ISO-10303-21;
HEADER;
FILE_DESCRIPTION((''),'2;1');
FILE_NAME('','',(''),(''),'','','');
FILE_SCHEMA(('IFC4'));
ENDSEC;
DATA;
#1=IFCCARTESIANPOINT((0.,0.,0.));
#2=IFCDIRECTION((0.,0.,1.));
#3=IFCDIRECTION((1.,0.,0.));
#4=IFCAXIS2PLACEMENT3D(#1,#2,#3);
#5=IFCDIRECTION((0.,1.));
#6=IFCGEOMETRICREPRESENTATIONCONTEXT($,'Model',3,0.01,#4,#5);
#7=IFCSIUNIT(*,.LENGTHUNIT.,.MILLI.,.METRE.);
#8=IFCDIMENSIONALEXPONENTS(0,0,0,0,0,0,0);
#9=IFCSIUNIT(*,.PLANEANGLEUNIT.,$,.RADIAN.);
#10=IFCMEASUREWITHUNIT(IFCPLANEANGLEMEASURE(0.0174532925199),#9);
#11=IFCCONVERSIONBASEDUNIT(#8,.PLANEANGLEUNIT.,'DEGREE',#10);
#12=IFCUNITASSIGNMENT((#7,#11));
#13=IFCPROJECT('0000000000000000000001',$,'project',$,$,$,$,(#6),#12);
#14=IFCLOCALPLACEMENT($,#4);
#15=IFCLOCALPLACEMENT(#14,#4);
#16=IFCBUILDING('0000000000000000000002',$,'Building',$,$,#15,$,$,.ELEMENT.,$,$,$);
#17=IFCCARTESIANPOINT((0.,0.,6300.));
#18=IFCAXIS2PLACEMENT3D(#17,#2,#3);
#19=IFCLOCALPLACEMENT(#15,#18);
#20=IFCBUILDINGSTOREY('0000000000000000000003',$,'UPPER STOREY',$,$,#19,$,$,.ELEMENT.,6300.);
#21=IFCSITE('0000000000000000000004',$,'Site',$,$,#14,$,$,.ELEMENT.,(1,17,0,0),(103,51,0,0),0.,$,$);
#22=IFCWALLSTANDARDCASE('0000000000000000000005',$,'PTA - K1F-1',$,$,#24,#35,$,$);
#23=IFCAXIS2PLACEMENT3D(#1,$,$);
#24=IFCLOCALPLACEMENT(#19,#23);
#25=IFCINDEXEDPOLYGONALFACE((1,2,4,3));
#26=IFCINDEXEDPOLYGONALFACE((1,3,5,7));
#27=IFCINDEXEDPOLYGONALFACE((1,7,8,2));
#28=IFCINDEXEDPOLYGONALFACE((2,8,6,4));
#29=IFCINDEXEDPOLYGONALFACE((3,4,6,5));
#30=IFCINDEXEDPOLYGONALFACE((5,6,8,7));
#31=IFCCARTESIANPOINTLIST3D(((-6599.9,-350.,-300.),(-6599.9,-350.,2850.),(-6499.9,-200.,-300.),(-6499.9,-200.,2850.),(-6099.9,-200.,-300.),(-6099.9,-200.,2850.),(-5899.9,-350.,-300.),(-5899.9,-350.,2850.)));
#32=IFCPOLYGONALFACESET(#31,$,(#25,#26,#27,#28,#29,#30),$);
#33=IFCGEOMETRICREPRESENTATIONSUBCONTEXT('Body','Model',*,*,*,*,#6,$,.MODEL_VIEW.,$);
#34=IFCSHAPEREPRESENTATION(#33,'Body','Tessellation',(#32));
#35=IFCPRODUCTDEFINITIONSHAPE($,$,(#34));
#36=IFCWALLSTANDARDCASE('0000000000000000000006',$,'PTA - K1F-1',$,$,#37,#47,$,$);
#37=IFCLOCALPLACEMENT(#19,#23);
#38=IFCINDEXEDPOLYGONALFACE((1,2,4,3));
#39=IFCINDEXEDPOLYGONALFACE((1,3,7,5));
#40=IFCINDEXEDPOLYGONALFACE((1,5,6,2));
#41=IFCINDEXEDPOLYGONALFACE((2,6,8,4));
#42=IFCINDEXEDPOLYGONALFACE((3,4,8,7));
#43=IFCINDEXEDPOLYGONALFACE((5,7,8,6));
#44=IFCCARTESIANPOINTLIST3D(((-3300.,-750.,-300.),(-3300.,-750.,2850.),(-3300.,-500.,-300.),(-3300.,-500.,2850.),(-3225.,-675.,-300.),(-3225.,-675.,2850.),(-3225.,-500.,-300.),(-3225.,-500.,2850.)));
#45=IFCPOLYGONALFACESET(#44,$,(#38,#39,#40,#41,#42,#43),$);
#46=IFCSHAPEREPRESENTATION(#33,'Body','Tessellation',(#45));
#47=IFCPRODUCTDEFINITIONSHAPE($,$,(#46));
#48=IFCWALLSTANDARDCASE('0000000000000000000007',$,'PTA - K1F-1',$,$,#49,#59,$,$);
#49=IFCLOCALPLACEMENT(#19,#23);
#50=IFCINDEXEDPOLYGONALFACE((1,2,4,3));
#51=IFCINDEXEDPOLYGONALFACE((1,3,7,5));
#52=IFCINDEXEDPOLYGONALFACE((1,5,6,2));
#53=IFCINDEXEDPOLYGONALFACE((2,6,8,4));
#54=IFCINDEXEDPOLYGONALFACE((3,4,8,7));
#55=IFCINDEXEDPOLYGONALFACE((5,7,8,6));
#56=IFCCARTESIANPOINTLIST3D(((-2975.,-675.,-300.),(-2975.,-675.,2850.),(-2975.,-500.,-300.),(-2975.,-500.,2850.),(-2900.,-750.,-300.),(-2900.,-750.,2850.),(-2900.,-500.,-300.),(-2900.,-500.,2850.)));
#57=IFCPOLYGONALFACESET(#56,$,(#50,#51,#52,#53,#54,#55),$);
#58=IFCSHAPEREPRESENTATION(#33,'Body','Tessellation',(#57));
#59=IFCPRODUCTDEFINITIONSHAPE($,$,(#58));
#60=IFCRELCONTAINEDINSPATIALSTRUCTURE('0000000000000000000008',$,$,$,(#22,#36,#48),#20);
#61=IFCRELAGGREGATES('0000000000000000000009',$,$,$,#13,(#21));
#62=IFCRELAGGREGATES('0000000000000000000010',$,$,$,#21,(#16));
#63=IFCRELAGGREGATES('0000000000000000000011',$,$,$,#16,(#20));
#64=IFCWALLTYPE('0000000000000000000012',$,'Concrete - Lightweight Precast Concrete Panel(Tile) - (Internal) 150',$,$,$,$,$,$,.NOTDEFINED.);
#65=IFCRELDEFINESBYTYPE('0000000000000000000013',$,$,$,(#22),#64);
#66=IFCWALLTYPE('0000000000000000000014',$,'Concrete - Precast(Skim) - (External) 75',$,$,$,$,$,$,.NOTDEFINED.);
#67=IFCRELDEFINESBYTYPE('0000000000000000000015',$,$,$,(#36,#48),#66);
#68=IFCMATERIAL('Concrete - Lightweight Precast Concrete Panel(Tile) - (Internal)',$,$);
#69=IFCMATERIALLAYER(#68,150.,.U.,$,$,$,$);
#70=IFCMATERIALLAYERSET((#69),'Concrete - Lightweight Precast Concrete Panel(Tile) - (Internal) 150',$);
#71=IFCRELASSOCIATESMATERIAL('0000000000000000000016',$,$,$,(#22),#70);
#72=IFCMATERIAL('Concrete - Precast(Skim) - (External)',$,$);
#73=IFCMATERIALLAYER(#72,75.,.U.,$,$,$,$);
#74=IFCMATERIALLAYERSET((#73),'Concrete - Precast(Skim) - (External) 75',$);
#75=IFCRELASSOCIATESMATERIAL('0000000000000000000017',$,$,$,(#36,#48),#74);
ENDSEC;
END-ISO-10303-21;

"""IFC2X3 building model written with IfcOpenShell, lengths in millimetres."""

from ifc_helpers import new_model, entity, si_unit, converted_unit, direction, frame, origin_with_axes, place, context, subcontext, project, spatial, polyline, outline, extrude, material, layer, layer_set, layer_usage, type_object, element, save


model = new_model("IFC2X3")

# Units and contexts
model_context = context("Model", 3, precision=0.01, world=origin_with_axes(), true_north=direction((0.0, 1.0)))
body_context = subcontext(model_context, "Body", "Model", "MODEL_VIEW")
ifc_project = project(units=[si_unit("LENGTHUNIT", "METRE", prefix="MILLI"), converted_unit("PLANEANGLEUNIT", "DEGREE", entity("IfcPlaneAngleMeasure", 0.0174532925199), si_unit("PLANEANGLEUNIT", "RADIAN"), dimensions=[0, 0, 0, 0, 0, 0, 0])], contexts=[model_context])

# Site, building, storey
site_placement = place(None, origin_with_axes())
site = spatial("IfcSite", under=ifc_project, at=site_placement, Name="Site", CompositionType="ELEMENT", RefLatitude=(1, 17, 0, 0), RefLongitude=(103, 51, 0, 0), RefElevation=0.0)
building_placement = place(site_placement, origin_with_axes())
building = spatial("IfcBuilding", under=site, at=building_placement, Name="Building", CompositionType="ELEMENT")
storey_placement = place(building_placement, frame((0.0, 0.0, 6300.0), z_axis=(0.0, 0.0, 1.0), x_axis=(1.0, 0.0, 0.0)))
storey = spatial("IfcBuildingStorey", under=building, at=storey_placement, Name="UPPER STOREY", CompositionType="ELEMENT", Elevation=6300.0)

# Shared definitions
ifc_material_1 = material(Name="Concrete - Precast(Skim) - (External)")

# Shared definitions
ifc_material_2 = material(Name="Concrete - Lightweight Precast Concrete Panel(Tile) - (Internal)")

# Walls
ifc_layer_1 = layer(ifc_material_2, 150.0, ventilated="UNKNOWN")
ifc_layer_set_1 = layer_set([ifc_layer_1], Name="Concrete - Lightweight Precast Concrete Panel(Tile) - (Internal) 150")
ifc_layer_usage_1 = layer_usage(ifc_layer_set_1, "AXIS2", "NEGATIVE", 0.0)
wall_type_1 = type_object("IfcWallType", Name="Concrete - Lightweight Precast Concrete Panel(Tile) - (Internal) 150", PredefinedType="NOTDEFINED")
wall_1_placement = place(storey_placement, frame((-5899.9, -350.0, -300.0), z_axis=(0.0, 0.0, 1.0), x_axis=(-1.0, 0.0, 0.0)))
element("IfcWallStandardCase", 1, at=wall_1_placement, inside=storey, type_object=wall_type_1, material=ifc_layer_usage_1, Name="PTA - K1F-1", context=body_context, shape_type="SweptSolid", body=[
    extrude(outline(polyline([(200.0, -150.0), (600.0, -150.0), (700.0, 0.0), (0.0, 0.0), (200.0, -150.0)])), origin_with_axes(), (0.0, 0.0, 1.0), 3150.0),
])
ifc_layer_2 = layer(ifc_material_1, 75.0, ventilated="UNKNOWN")
ifc_layer_set_2 = layer_set([ifc_layer_2], Name="Concrete - Precast(Skim) - (External) 75")
ifc_layer_usage_2 = layer_usage(ifc_layer_set_2, "AXIS2", "POSITIVE", 0.0)
wall_type_2 = type_object("IfcWallType", Name="Concrete - Precast(Skim) - (External) 75", PredefinedType="NOTDEFINED")
wall_2_placement = place(storey_placement, frame((-3300.0, -500.0, -300.0), z_axis=(0.0, 0.0, 1.0), x_axis=(0.0, -1.0, 0.0)))
element("IfcWallStandardCase", 2, at=wall_2_placement, inside=storey, type_object=wall_type_2, material=ifc_layer_usage_2, Name="PTA - K1F-1", context=body_context, shape_type="SweptSolid", body=[
    extrude(outline(polyline([(0.0, 0.0), (250.0, 0.0), (175.0, 75.0), (0.0, 75.0), (0.0, 0.0)])), origin_with_axes(), (0.0, 0.0, 1.0), 3150.0),
])
ifc_layer_usage_3 = layer_usage(ifc_layer_set_2, "AXIS2", "NEGATIVE", 0.0)
wall_3_placement = place(storey_placement, frame((-2900.0, -500.0, -300.0), z_axis=(0.0, 0.0, 1.0), x_axis=(0.0, -1.0, 0.0)))
element("IfcWallStandardCase", 3, at=wall_3_placement, inside=storey, type_object=wall_type_2, material=ifc_layer_usage_3, Name="PTA - K1F-1", context=body_context, shape_type="SweptSolid", body=[
    extrude(outline(polyline([(0.0, -75.0), (175.0, -75.0), (250.0, 0.0), (0.0, 0.0), (0.0, -75.0)])), origin_with_axes(), (0.0, 0.0, 1.0), 3150.0),
])

save(model, "model.ifc")
